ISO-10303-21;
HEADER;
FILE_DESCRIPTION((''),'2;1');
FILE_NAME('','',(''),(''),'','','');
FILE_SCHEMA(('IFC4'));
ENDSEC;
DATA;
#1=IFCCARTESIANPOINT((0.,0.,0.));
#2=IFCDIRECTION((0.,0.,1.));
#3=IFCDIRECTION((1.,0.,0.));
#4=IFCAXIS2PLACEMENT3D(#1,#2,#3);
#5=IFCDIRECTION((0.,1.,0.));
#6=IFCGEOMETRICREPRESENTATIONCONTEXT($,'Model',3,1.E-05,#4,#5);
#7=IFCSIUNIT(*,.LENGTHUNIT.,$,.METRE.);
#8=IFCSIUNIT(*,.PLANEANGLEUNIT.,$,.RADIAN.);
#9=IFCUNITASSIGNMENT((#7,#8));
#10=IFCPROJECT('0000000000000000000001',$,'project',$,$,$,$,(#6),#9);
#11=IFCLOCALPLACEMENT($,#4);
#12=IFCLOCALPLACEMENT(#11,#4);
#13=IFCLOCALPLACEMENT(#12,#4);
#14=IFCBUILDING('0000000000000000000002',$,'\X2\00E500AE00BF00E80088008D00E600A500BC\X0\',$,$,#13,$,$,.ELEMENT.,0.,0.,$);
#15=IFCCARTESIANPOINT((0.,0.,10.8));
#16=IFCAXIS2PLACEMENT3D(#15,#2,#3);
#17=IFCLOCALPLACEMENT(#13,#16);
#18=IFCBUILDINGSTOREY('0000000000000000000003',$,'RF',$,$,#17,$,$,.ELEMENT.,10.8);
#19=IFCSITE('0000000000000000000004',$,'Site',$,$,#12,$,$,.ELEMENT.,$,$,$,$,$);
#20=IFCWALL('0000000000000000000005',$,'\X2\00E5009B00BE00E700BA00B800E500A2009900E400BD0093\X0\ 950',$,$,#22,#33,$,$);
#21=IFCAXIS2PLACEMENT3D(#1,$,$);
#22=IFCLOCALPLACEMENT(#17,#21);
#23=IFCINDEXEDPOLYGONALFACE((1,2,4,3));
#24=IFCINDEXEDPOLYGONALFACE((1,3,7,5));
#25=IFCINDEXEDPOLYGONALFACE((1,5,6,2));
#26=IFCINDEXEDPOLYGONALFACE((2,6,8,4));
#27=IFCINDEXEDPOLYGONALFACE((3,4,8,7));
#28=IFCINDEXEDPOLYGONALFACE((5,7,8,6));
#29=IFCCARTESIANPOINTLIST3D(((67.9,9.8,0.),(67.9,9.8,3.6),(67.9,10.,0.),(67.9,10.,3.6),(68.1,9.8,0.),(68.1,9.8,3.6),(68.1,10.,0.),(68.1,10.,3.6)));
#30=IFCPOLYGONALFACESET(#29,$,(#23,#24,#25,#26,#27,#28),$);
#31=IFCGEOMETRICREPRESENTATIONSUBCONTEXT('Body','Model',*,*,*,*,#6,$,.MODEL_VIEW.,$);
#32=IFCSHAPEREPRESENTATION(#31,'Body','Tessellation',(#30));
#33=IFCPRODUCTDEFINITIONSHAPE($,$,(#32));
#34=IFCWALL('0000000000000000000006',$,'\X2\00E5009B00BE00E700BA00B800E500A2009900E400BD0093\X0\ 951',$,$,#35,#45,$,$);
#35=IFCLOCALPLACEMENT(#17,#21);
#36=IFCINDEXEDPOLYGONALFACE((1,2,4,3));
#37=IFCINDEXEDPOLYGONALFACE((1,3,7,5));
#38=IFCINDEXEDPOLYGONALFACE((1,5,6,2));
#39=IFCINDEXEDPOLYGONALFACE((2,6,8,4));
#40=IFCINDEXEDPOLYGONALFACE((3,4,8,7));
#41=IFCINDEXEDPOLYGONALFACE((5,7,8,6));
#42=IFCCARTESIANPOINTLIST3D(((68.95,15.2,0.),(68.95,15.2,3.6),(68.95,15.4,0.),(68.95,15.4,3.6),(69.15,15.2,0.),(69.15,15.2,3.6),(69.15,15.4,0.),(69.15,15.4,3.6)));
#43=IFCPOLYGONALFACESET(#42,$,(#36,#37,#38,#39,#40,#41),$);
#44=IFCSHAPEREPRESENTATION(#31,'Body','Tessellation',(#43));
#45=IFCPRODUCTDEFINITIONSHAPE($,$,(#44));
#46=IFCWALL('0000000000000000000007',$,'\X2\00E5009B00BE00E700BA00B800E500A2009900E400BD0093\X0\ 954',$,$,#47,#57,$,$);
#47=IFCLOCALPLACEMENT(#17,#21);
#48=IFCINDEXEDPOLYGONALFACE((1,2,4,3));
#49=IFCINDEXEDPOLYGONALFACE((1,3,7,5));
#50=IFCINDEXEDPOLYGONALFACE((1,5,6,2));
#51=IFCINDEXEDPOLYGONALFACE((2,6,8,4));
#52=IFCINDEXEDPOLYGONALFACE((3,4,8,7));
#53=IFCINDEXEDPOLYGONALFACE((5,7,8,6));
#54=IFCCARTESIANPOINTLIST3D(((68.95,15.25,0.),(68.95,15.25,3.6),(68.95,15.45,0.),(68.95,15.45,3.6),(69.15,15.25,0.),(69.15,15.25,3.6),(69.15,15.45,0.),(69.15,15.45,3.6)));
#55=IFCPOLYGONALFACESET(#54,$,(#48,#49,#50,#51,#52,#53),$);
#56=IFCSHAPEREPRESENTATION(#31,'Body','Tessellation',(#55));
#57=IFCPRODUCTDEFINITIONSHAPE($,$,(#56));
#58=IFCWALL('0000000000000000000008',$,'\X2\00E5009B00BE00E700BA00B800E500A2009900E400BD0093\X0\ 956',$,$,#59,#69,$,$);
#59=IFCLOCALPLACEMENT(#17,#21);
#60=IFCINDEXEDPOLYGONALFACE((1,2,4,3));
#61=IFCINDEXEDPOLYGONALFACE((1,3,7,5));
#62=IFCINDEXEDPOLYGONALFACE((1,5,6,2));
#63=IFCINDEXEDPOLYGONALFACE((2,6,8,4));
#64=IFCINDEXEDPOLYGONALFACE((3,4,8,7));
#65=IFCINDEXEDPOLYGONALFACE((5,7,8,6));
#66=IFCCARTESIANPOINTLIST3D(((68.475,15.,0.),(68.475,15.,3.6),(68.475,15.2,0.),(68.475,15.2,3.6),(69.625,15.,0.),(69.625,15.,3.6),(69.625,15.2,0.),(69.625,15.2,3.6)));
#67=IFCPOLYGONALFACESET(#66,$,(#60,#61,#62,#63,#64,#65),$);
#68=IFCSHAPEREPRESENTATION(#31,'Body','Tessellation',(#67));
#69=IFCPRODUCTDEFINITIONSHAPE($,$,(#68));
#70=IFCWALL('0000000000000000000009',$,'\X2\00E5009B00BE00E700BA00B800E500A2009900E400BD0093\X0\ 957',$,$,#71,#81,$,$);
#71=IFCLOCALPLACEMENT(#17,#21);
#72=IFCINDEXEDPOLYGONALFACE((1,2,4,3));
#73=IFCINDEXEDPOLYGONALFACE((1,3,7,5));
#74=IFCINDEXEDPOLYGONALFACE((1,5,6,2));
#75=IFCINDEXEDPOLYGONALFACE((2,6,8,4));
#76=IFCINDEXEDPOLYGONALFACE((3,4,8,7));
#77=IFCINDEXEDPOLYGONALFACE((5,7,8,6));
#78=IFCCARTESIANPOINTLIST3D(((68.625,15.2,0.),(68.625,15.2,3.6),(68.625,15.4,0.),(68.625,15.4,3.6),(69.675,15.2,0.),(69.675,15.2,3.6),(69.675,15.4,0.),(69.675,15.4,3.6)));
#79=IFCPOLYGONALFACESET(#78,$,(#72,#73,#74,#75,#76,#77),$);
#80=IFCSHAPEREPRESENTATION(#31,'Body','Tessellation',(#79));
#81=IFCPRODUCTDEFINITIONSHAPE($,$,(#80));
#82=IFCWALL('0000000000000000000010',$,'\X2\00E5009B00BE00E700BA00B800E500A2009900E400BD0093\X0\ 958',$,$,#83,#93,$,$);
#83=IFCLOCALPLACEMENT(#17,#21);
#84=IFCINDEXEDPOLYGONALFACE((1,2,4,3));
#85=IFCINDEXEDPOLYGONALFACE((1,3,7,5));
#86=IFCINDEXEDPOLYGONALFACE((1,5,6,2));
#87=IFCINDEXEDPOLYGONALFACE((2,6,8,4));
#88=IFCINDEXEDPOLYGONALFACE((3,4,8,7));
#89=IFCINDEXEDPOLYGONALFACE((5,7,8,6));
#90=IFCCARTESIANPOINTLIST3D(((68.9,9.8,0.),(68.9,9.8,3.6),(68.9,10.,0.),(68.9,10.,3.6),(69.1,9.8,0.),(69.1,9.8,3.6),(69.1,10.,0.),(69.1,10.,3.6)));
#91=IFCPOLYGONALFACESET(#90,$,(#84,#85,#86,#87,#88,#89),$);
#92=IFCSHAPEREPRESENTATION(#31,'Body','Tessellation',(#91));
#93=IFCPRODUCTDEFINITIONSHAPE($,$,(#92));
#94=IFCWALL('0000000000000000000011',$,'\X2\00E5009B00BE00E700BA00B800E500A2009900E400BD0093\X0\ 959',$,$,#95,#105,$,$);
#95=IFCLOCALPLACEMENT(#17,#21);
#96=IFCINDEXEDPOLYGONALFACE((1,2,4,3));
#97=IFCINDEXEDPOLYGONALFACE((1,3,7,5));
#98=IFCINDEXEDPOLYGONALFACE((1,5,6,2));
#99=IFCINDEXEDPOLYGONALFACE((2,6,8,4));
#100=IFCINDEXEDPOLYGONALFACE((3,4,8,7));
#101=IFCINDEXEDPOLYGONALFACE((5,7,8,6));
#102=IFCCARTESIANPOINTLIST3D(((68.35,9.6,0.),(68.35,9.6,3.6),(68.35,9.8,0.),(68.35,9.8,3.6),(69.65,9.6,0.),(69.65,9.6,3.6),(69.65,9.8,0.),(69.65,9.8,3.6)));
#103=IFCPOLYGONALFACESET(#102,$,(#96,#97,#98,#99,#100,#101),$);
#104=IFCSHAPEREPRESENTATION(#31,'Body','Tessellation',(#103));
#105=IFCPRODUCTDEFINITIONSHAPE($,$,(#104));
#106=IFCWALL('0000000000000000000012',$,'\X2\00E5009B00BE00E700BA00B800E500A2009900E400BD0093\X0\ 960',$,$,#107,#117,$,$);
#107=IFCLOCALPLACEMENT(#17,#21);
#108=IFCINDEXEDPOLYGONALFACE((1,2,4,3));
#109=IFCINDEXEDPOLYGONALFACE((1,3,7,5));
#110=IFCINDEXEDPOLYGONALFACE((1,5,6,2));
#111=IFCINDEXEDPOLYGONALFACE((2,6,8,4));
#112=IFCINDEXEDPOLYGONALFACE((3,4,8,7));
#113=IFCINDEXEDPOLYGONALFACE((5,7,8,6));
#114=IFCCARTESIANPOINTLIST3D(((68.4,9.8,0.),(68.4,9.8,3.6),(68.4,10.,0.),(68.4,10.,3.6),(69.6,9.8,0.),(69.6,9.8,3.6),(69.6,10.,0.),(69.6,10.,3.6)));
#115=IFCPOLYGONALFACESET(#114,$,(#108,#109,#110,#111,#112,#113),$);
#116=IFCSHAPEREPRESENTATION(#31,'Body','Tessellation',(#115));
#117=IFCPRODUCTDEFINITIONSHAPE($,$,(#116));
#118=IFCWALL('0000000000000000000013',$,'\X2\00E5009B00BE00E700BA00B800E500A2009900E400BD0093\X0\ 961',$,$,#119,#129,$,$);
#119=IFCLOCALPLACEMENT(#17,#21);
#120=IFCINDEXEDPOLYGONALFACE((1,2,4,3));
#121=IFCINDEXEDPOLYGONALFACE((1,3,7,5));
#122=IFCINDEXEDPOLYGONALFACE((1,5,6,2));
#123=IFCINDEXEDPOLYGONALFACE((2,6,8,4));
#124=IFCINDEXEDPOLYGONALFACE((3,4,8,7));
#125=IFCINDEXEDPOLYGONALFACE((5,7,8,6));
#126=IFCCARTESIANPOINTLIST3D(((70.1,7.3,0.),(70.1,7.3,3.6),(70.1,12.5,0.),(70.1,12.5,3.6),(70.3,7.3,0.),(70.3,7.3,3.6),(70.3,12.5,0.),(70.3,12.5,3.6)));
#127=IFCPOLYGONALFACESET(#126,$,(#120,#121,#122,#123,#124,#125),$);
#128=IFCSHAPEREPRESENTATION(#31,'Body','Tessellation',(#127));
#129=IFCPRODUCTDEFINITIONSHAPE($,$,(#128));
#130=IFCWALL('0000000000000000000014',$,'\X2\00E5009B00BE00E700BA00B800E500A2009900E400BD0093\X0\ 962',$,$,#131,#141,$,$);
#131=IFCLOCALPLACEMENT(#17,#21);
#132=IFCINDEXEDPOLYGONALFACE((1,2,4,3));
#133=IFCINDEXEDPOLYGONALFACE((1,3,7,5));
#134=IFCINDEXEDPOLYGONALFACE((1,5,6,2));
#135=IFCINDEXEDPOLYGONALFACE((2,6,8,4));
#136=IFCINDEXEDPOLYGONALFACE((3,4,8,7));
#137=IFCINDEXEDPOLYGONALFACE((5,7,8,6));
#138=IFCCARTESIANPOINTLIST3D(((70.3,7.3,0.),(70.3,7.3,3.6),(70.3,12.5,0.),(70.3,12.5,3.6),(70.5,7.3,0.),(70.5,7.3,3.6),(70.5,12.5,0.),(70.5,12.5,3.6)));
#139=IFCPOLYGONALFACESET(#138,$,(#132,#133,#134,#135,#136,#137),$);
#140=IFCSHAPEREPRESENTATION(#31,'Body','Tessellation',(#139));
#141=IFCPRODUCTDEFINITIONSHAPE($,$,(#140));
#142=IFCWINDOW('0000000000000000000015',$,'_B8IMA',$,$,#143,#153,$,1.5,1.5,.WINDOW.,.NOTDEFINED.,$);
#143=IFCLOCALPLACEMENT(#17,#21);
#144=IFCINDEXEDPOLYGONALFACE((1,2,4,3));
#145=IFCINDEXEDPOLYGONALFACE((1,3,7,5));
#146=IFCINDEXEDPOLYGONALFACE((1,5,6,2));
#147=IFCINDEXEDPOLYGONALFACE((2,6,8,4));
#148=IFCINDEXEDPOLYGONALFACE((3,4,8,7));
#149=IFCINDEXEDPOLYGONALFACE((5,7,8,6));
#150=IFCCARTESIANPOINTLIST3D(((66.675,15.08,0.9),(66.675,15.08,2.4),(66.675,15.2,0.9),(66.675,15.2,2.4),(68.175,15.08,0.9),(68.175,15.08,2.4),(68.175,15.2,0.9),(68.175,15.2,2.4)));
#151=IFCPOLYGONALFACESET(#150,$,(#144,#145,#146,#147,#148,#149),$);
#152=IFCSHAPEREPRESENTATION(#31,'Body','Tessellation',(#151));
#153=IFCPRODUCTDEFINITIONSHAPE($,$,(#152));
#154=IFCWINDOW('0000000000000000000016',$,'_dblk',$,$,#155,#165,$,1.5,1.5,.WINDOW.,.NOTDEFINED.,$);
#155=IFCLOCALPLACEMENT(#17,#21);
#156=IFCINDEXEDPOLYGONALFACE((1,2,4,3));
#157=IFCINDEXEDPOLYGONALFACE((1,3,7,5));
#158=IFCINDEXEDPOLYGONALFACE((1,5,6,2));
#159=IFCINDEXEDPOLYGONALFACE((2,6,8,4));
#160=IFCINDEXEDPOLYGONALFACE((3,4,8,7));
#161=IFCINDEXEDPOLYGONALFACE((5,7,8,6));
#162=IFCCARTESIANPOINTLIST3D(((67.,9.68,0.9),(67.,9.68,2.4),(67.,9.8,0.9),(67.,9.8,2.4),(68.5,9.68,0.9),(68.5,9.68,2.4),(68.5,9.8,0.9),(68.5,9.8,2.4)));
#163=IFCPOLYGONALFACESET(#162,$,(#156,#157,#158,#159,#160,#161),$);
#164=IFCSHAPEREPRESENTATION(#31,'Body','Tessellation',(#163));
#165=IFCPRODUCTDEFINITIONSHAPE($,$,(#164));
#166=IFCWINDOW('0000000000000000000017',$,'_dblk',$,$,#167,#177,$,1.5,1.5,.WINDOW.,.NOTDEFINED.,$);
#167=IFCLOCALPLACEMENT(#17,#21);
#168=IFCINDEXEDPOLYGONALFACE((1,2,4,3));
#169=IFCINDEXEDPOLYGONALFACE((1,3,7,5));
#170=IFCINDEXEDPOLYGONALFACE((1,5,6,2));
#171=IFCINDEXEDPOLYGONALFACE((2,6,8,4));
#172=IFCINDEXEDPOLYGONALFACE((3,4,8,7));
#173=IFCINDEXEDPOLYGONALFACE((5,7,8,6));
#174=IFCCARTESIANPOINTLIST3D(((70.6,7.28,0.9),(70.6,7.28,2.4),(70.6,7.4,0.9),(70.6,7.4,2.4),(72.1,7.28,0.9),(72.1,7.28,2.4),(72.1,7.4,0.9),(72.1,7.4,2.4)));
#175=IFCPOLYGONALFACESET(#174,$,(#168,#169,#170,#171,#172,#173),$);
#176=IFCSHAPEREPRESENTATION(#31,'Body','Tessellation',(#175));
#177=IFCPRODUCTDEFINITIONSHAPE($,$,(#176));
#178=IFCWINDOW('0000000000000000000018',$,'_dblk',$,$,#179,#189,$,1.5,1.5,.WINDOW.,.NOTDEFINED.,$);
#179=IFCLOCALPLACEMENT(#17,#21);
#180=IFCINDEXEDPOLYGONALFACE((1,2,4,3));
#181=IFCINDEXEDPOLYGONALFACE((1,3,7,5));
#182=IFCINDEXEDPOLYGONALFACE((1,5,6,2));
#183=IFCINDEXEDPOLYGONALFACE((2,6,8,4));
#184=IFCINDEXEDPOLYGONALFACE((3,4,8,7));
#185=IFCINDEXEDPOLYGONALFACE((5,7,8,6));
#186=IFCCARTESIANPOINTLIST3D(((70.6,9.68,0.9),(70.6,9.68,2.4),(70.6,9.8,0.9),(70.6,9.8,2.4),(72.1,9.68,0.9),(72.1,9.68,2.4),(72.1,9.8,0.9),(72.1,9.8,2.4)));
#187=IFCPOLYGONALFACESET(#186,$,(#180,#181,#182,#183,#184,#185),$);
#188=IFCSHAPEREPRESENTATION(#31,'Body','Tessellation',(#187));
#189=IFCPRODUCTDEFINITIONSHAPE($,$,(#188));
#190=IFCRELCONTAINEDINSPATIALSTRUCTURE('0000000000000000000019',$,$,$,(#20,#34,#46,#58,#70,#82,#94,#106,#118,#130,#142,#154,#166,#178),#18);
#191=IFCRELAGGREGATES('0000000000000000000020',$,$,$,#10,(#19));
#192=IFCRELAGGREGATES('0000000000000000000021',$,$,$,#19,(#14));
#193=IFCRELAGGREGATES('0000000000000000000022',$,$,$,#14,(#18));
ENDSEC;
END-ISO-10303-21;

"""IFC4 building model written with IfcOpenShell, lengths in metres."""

from ifc_helpers import new_model, si_unit, direction, frame, frame_2d, origin_with_axes, place, context, subcontext, project, spatial, rectangle, extrude, element, save


model = new_model("IFC4")

# Units and contexts
model_context = context("Model", 3, precision=1e-05, world=origin_with_axes(), true_north=direction((0.0, 1.0, 0.0)))
body_context = subcontext(model_context, "Body", "Model", "MODEL_VIEW")
ifc_project = project(units=[si_unit("LENGTHUNIT", "METRE"), si_unit("PLANEANGLEUNIT", "RADIAN")], contexts=[model_context])

# Site, building, storey
placement = place(None, origin_with_axes())
site_placement = place(placement, origin_with_axes())
site = spatial("IfcSite", under=ifc_project, at=site_placement, Name="Site", CompositionType="ELEMENT")
building_placement = place(site_placement, origin_with_axes())
building = spatial("IfcBuilding", under=site, at=building_placement, Name="å®¿è\u0088\u008dæ¥¼", CompositionType="ELEMENT", ElevationOfRefHeight=0.0, ElevationOfTerrain=0.0)
storey_placement = place(building_placement, frame((0.0, 0.0, 10.8), z_axis=(0.0, 0.0, 1.0), x_axis=(1.0, 0.0, 0.0)))
storey = spatial("IfcBuildingStorey", under=building, at=storey_placement, Name="RF", CompositionType="ELEMENT", Elevation=10.8)

# Walls
for number, where, z_axis, x_axis, name in (
    (1, (68.0, 9.9, 0.0), (0.0, 0.0, 1.0), (0.0, -1.0, 0.0), "å\u009b¾çº¸å¢\u0099ä½\u0093 950"),
    (2, (69.05, 15.3, 0.0), (0.0, 0.0, 1.0), (0.0, -1.0, 0.0), "å\u009b¾çº¸å¢\u0099ä½\u0093 951"),
    (3, (69.05, 15.35, 0.0), (0.0, 0.0, 1.0), (0.0, -1.0, 0.0), "å\u009b¾çº¸å¢\u0099ä½\u0093 954"),
):
    element("IfcWall", number, at=place(storey_placement, frame(where, z_axis=z_axis, x_axis=x_axis)), inside=storey, Name=name, context=body_context, shape_type="SweptSolid", body=[
        extrude(rectangle(XDim=0.2, YDim=0.2, at=frame_2d((0.0, 0.0), x_axis=(1.0, 0.0, 0.0))), frame((0.0, 0.0, 0.0), z_axis=(0.0, 0.0, 1.0)), (0.0, 0.0, 1.0), 3.6),
    ])
wall_1_placement = place(storey_placement, frame((69.05, 15.1, 0.0), z_axis=(0.0, 0.0, 1.0), x_axis=(1.0, 0.0, 0.0)))
element("IfcWall", 4, at=wall_1_placement, inside=storey, Name="å\u009b¾çº¸å¢\u0099ä½\u0093 956", context=body_context, shape_type="SweptSolid", body=[
    extrude(rectangle(XDim=1.15, YDim=0.2, at=frame_2d((0.0, 0.0), x_axis=(1.0, 0.0, 0.0))), frame((0.0, 0.0, 0.0), z_axis=(0.0, 0.0, 1.0)), (0.0, 0.0, 1.0), 3.6),
])
wall_2_placement = place(storey_placement, frame((69.15, 15.3, 0.0), z_axis=(0.0, 0.0, 1.0), x_axis=(1.0, 0.0, 0.0)))
element("IfcWall", 5, at=wall_2_placement, inside=storey, Name="å\u009b¾çº¸å¢\u0099ä½\u0093 957", context=body_context, shape_type="SweptSolid", body=[
    extrude(rectangle(XDim=1.05, YDim=0.2, at=frame_2d((0.0, 0.0), x_axis=(1.0, 0.0, 0.0))), frame((0.0, 0.0, 0.0), z_axis=(0.0, 0.0, 1.0)), (0.0, 0.0, 1.0), 3.6),
])
wall_3_placement = place(storey_placement, frame((69.0, 9.9, 0.0), z_axis=(0.0, 0.0, 1.0), x_axis=(0.0, -1.0, 0.0)))
element("IfcWall", 6, at=wall_3_placement, inside=storey, Name="å\u009b¾çº¸å¢\u0099ä½\u0093 958", context=body_context, shape_type="SweptSolid", body=[
    extrude(rectangle(XDim=0.2, YDim=0.2, at=frame_2d((0.0, 0.0), x_axis=(1.0, 0.0, 0.0))), frame((0.0, 0.0, 0.0), z_axis=(0.0, 0.0, 1.0)), (0.0, 0.0, 1.0), 3.6),
])
wall_4_placement = place(storey_placement, frame((69.0, 9.7, 0.0), z_axis=(0.0, 0.0, 1.0), x_axis=(1.0, 0.0, 0.0)))
element("IfcWall", 7, at=wall_4_placement, inside=storey, Name="å\u009b¾çº¸å¢\u0099ä½\u0093 959", context=body_context, shape_type="SweptSolid", body=[
    extrude(rectangle(XDim=1.3, YDim=0.2, at=frame_2d((0.0, 0.0), x_axis=(1.0, 0.0, 0.0))), frame((0.0, 0.0, 0.0), z_axis=(0.0, 0.0, 1.0)), (0.0, 0.0, 1.0), 3.6),
])
wall_5_placement = place(storey_placement, frame((69.0, 9.9, 0.0), z_axis=(0.0, 0.0, 1.0), x_axis=(1.0, 0.0, 0.0)))
element("IfcWall", 8, at=wall_5_placement, inside=storey, Name="å\u009b¾çº¸å¢\u0099ä½\u0093 960", context=body_context, shape_type="SweptSolid", body=[
    extrude(rectangle(XDim=1.2, YDim=0.2, at=frame_2d((0.0, 0.0), x_axis=(1.0, 0.0, 0.0))), frame((0.0, 0.0, 0.0), z_axis=(0.0, 0.0, 1.0)), (0.0, 0.0, 1.0), 3.6),
])
for number, where, z_axis, x_axis, name in (
    (9, (70.2, 9.9, 0.0), (0.0, 0.0, 1.0), (0.0, 1.0, 0.0), "å\u009b¾çº¸å¢\u0099ä½\u0093 961"),
    (10, (70.4, 9.9, 0.0), (0.0, 0.0, 1.0), (0.0, 1.0, 0.0), "å\u009b¾çº¸å¢\u0099ä½\u0093 962"),
):
    element("IfcWall", number, at=place(storey_placement, frame(where, z_axis=z_axis, x_axis=x_axis)), inside=storey, Name=name, context=body_context, shape_type="SweptSolid", body=[
        extrude(rectangle(XDim=5.2, YDim=0.2, at=frame_2d((0.0, 0.0), x_axis=(1.0, 0.0, 0.0))), frame((0.0, 0.0, 0.0), z_axis=(0.0, 0.0, 1.0)), (0.0, 0.0, 1.0), 3.6),
    ])

# Windows
for number, where, z_axis, x_axis, name in (
    (11, (67.425, 15.14, 0.9), (0.0, 0.0, 1.0), (1.0, 0.0, 0.0), "_B8IMA"),
    (12, (67.75, 9.74, 0.9), (0.0, 0.0, 1.0), (1.0, 0.0, 0.0), "_dblk"),
    (13, (71.35, 7.34, 0.9), (0.0, 0.0, 1.0), (1.0, 0.0, 0.0), "_dblk"),
    (14, (71.35, 9.74, 0.9), (0.0, 0.0, 1.0), (1.0, 0.0, 0.0), "_dblk"),
):
    element("IfcWindow", number, at=place(storey_placement, frame(where, z_axis=z_axis, x_axis=x_axis)), inside=storey, Name=name, OverallHeight=1.5, OverallWidth=1.5, PartitioningType="NOTDEFINED", PredefinedType="WINDOW", context=body_context, shape_type="SweptSolid", body=[
        extrude(rectangle(XDim=1.5, YDim=0.12, at=frame_2d((0.0, 0.0), x_axis=(1.0, 0.0, 0.0))), frame((0.0, 0.0, 0.0), z_axis=(0.0, 0.0, 1.0)), (0.0, 0.0, 1.0), 1.5),
    ])

save(model, "model.ifc")
